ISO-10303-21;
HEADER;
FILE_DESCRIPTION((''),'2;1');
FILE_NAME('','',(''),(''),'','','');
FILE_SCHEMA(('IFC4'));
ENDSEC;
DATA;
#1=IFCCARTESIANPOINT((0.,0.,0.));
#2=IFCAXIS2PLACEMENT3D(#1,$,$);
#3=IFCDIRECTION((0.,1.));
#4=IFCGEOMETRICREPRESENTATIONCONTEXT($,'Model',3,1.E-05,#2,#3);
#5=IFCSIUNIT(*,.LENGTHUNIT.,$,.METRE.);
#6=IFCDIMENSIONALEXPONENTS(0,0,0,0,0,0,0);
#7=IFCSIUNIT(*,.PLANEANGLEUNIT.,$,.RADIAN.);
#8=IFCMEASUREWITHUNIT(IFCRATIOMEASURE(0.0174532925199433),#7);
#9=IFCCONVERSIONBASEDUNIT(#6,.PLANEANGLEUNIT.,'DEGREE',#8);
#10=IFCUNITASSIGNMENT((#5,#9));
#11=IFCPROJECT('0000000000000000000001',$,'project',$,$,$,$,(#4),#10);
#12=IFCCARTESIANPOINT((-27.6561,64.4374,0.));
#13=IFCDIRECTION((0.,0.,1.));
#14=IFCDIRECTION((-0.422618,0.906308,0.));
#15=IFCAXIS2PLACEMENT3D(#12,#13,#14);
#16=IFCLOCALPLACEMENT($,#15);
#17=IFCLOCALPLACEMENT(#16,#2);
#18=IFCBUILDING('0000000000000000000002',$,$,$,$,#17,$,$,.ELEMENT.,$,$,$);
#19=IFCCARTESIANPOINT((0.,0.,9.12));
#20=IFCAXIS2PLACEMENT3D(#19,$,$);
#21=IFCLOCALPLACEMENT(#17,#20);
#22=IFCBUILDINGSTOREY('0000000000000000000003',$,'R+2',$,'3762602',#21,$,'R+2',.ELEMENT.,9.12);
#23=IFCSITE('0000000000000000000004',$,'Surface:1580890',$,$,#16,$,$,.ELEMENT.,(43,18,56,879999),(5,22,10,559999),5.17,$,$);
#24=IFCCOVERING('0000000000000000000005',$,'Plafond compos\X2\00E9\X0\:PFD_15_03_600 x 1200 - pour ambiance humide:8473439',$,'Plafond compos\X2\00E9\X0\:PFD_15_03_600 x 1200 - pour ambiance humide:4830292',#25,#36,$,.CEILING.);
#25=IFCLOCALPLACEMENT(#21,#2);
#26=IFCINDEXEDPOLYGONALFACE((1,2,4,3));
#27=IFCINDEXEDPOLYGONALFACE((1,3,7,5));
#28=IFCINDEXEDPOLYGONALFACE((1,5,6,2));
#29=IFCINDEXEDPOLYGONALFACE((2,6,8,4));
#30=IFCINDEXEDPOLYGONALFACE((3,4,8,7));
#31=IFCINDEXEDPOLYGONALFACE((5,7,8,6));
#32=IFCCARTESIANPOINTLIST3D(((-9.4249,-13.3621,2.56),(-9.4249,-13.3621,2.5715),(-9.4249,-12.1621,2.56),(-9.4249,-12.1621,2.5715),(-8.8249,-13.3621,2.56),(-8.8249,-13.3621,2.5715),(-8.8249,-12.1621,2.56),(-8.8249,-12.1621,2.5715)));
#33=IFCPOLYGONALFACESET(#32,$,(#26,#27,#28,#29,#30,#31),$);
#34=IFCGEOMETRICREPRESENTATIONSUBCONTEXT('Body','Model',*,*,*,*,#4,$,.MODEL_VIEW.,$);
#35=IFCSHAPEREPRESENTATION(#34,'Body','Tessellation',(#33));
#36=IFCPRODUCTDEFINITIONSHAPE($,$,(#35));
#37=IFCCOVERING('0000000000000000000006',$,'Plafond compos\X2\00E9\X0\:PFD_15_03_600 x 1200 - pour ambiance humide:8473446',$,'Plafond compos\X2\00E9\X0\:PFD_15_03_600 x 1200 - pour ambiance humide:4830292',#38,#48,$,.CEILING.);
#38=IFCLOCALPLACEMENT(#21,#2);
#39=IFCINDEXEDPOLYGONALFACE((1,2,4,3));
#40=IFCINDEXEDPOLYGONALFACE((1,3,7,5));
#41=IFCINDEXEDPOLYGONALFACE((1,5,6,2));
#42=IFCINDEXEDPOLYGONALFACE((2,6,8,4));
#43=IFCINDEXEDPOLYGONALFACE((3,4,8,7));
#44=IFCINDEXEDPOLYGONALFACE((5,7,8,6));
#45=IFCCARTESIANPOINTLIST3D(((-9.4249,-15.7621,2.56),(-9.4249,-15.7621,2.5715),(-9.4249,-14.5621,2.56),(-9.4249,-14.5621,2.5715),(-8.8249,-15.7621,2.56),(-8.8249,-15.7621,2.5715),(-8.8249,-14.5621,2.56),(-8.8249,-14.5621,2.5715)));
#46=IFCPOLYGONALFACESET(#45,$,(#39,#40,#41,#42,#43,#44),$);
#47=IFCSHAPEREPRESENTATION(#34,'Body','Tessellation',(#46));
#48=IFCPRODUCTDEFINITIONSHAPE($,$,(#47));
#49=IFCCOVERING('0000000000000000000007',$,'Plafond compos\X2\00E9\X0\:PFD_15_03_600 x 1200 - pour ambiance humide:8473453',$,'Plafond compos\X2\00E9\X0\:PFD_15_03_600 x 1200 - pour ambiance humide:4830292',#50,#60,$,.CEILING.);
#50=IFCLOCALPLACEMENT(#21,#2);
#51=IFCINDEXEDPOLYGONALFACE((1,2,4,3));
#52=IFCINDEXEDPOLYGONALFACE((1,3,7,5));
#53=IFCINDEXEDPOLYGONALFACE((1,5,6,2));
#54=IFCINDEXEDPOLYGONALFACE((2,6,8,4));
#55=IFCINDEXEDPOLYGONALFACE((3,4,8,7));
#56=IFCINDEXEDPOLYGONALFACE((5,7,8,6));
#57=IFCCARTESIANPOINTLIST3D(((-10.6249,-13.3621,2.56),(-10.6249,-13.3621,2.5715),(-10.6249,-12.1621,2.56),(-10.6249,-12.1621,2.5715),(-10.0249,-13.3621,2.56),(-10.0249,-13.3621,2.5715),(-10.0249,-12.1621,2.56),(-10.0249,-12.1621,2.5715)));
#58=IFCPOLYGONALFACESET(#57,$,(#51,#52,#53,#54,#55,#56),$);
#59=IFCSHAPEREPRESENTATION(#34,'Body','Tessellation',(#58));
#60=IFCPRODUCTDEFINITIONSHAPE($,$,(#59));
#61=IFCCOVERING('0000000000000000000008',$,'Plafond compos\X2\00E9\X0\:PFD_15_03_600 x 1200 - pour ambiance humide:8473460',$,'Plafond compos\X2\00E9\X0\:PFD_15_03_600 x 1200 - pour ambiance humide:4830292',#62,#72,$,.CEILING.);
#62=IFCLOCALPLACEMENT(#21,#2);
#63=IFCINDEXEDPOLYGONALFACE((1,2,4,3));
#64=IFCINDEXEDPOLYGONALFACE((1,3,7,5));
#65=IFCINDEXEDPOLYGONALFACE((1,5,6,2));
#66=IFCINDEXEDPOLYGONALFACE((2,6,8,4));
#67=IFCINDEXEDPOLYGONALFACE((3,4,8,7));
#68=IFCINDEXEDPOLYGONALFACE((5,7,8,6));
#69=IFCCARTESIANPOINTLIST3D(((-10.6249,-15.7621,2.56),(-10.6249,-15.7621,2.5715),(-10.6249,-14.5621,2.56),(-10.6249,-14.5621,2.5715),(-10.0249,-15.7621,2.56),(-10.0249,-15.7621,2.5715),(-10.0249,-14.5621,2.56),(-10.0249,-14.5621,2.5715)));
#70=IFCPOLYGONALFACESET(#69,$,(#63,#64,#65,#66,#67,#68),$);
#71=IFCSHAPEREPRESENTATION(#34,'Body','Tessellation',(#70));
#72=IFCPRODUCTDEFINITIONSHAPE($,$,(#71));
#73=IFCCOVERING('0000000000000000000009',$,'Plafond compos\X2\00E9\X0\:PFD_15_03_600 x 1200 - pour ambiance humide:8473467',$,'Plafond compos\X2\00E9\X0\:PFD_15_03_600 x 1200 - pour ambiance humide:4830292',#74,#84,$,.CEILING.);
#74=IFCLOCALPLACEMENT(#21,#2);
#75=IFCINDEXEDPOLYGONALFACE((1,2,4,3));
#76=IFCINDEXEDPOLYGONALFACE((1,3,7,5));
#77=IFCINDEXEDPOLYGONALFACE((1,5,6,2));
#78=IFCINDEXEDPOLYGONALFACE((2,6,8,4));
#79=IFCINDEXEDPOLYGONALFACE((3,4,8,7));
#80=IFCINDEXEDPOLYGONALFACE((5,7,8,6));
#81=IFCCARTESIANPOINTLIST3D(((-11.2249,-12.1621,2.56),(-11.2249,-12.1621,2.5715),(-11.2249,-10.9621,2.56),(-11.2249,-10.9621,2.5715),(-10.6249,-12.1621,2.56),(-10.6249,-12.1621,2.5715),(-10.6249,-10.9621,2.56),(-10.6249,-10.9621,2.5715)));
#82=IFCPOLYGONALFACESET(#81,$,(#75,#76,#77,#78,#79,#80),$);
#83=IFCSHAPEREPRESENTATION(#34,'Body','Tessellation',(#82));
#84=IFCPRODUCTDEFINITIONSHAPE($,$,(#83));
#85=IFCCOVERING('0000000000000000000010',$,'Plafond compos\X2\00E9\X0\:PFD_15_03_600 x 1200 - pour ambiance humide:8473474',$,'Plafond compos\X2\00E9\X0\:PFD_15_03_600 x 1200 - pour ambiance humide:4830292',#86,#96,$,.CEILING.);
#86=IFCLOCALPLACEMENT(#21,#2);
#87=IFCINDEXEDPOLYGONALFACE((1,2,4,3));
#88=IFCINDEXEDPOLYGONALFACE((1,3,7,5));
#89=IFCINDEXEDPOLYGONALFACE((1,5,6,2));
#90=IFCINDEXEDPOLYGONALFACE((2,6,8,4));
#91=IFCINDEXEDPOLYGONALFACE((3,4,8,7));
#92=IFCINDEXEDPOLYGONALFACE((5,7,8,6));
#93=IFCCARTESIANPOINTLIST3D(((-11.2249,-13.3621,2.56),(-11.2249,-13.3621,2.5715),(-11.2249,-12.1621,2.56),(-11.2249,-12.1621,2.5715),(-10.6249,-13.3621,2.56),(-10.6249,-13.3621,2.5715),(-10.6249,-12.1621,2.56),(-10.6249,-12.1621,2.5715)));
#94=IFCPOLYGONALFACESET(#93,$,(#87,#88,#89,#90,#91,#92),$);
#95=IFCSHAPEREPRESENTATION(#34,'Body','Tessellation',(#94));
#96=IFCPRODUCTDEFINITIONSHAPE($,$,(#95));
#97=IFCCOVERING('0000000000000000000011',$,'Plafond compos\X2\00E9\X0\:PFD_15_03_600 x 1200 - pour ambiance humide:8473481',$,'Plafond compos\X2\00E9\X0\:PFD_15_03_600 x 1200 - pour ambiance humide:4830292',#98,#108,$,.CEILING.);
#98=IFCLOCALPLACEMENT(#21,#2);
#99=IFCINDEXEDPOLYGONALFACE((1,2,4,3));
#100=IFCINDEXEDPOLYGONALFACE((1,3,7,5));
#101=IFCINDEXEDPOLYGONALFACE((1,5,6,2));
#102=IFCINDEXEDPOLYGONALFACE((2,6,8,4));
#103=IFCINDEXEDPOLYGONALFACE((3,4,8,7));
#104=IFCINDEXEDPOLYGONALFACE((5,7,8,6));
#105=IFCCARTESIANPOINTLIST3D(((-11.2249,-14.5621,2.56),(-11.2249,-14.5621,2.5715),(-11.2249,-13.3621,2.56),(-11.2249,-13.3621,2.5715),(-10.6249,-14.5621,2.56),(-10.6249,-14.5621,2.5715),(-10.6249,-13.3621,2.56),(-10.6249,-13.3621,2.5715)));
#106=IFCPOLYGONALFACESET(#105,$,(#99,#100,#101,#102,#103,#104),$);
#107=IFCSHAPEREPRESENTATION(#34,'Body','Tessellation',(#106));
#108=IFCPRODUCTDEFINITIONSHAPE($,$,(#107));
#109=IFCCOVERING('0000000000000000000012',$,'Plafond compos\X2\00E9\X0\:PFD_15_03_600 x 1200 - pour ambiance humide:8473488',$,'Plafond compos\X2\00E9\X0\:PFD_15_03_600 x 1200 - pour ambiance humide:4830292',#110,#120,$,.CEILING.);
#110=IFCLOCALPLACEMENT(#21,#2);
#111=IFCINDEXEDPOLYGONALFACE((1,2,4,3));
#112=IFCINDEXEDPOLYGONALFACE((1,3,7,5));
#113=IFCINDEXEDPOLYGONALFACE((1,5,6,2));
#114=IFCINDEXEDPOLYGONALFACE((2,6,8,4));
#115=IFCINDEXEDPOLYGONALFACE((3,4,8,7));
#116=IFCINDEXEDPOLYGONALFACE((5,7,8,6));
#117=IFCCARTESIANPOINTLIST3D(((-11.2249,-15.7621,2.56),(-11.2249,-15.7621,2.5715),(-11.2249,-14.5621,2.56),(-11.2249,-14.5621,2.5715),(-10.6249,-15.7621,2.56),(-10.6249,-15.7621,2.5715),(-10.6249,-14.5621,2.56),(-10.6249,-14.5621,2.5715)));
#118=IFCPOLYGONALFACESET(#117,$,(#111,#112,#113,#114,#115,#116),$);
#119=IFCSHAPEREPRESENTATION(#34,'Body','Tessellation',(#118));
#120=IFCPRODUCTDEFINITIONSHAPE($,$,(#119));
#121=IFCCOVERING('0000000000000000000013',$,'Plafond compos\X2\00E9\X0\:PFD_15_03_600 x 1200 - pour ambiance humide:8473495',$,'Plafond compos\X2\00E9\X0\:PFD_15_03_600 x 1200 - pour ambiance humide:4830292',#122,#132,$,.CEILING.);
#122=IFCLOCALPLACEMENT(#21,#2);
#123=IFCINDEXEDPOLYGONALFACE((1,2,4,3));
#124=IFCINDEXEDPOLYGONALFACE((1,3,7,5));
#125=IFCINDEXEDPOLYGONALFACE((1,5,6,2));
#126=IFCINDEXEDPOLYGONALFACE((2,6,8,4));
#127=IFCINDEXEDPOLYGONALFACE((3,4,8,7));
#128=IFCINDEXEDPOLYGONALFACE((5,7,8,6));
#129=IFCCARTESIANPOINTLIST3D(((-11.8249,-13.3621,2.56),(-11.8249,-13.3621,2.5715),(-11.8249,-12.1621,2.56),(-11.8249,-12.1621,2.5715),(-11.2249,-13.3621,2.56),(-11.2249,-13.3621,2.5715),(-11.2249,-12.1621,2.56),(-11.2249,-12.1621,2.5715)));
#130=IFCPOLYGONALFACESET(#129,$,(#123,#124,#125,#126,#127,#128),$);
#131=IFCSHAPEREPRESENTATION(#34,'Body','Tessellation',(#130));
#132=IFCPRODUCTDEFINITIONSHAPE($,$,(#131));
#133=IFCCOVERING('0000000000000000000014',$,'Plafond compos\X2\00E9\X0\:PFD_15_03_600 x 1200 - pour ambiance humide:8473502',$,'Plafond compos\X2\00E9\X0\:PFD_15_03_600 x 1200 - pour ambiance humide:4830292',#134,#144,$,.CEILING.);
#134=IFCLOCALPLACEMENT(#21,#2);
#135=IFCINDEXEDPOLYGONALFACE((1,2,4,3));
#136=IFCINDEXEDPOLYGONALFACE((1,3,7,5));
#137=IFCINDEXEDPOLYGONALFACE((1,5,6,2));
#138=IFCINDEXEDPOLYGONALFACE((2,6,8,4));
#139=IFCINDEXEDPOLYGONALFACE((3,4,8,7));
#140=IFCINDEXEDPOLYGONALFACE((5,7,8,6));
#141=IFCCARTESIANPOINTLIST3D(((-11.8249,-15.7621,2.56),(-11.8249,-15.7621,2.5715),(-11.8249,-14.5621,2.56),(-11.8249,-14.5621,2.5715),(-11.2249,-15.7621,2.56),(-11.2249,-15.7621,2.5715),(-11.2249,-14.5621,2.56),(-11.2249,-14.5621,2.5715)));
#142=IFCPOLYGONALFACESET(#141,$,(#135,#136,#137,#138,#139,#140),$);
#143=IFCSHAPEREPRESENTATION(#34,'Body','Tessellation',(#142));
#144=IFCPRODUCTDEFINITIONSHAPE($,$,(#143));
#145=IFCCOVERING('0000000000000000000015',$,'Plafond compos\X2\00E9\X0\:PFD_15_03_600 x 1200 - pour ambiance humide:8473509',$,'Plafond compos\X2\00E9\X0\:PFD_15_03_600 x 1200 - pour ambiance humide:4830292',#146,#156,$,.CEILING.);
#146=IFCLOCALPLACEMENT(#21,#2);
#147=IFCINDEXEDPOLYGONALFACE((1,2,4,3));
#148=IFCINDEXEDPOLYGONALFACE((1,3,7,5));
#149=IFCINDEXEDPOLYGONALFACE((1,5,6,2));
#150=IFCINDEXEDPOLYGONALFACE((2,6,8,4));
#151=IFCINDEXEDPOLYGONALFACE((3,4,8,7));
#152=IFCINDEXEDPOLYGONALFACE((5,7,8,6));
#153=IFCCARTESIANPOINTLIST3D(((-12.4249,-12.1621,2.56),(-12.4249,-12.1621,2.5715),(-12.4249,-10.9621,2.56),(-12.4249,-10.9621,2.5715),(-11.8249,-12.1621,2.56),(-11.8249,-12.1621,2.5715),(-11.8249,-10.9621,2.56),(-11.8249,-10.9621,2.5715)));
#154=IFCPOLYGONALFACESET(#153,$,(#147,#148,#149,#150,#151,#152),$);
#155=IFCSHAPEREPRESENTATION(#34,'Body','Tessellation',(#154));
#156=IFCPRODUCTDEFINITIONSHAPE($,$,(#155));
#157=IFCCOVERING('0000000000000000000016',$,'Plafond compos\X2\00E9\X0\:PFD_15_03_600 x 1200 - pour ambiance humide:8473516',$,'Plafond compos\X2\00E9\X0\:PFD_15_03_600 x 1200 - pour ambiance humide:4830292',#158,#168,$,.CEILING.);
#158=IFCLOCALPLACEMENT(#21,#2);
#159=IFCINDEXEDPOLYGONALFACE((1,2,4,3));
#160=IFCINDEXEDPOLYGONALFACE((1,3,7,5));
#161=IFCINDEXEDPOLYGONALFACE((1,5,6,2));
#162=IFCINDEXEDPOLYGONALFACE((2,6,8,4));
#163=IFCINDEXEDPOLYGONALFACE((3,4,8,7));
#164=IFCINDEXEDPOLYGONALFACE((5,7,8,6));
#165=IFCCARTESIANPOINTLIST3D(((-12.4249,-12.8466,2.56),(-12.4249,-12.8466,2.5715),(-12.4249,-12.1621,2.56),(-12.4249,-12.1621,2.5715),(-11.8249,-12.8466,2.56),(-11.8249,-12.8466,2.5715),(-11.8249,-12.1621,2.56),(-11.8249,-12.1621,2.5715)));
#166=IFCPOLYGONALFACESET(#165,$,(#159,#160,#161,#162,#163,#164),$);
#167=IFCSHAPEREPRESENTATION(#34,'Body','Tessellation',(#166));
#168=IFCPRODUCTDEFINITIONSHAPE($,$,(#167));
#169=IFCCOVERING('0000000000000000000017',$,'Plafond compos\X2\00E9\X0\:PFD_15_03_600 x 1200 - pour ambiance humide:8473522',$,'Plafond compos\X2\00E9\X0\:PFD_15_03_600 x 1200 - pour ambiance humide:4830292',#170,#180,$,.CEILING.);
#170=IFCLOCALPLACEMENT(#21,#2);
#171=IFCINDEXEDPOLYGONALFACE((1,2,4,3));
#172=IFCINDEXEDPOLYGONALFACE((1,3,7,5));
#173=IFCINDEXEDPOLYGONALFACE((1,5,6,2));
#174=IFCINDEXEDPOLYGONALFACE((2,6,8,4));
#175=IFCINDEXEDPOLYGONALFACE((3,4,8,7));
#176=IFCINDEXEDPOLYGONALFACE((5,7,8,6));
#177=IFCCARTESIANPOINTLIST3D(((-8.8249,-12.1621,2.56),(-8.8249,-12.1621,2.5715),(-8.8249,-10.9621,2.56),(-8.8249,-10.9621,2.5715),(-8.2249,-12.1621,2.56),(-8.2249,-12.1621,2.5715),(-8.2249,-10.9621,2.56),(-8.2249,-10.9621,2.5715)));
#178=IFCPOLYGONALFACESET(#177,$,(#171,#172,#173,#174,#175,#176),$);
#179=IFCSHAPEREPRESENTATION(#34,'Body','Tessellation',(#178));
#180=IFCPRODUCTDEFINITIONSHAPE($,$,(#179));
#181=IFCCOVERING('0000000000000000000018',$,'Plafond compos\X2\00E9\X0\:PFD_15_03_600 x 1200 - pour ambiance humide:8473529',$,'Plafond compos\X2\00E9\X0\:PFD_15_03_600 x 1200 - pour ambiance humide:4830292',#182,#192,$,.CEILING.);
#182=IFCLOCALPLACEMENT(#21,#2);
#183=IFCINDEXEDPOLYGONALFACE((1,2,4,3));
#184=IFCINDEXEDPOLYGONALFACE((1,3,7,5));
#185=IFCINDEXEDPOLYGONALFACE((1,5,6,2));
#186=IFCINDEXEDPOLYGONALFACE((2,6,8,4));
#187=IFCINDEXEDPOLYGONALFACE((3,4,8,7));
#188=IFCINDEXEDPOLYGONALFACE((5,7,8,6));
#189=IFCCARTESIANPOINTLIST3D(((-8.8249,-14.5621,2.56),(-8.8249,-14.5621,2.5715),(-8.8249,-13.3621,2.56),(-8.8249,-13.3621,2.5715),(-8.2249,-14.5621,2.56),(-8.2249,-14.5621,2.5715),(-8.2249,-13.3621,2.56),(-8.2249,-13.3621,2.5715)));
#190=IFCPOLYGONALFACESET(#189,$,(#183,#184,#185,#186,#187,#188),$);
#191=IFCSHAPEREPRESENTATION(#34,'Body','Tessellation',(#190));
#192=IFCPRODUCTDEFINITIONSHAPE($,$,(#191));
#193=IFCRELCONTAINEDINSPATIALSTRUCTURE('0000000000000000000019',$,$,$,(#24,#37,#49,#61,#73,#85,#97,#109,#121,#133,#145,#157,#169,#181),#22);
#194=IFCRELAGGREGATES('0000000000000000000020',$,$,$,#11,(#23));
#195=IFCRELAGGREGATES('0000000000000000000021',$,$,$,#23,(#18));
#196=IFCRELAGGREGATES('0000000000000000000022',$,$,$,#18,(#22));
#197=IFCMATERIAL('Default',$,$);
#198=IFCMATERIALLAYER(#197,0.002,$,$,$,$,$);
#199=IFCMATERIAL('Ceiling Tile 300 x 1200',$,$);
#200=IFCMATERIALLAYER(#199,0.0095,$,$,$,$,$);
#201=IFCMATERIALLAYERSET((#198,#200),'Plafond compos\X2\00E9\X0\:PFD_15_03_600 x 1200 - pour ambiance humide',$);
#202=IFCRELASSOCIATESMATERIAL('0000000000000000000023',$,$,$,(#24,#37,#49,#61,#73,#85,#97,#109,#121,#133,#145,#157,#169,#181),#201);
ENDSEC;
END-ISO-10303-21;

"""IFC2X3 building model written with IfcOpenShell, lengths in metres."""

from ifc_helpers import new_model, entity, si_unit, converted_unit, direction, frame, frame_2d, origin, origin_2d_with_axis, place, context, subcontext, project, spatial, rectangle, extrude, material, layer, layer_set, layer_usage, element, save


model = new_model("IFC2X3")

# Units and contexts
model_context = context("Model", 3, precision=1e-05, world=origin(), true_north=direction((0.0, 1.0)))
body_context = subcontext(model_context, "Body", "Model", "MODEL_VIEW")
ifc_project = project(units=[si_unit("LENGTHUNIT", "METRE"), converted_unit("PLANEANGLEUNIT", "DEGREE", entity("IfcRatioMeasure", 0.0174532925199433), si_unit("PLANEANGLEUNIT", "RADIAN"), dimensions=[0, 0, 0, 0, 0, 0, 0])], contexts=[model_context])

# Site, building, storey
site_placement = place(None, frame((-27.6561, 64.4374, 0.0), z_axis=(0.0, 0.0, 1.0), x_axis=(-0.422618, 0.906308, 0.0)))
site = spatial("IfcSite", under=ifc_project, at=site_placement, Name="Surface:1580890", CompositionType="ELEMENT", RefLatitude=(43, 18, 56, 879999), RefLongitude=(5, 22, 10, 559999), RefElevation=5.17)
building_placement = place(site_placement, origin())
building = spatial("IfcBuilding", under=site, at=building_placement, CompositionType="ELEMENT")
storey_placement = place(building_placement, frame((0.0, 0.0, 9.12)))
storey = spatial("IfcBuildingStorey", under=building, at=storey_placement, Name="R+2", ObjectType="3762602", LongName="R+2", CompositionType="ELEMENT", Elevation=9.12)

# Coverings
ifc_material_1 = material(Name="Default")
ifc_layer_1 = layer(ifc_material_1, 0.002)
ifc_material_2 = material(Name="Ceiling Tile 300 x 1200")
ifc_layer_2 = layer(ifc_material_2, 0.0095)
ifc_layer_set = layer_set([ifc_layer_1, ifc_layer_2], Name="Plafond composé:PFD_15_03_600 x 1200 - pour ambiance humide")
ifc_layer_usage_1 = layer_usage(ifc_layer_set, "AXIS3", "POSITIVE", 0.0)
covering_1_placement = place(storey_placement, origin())
element("IfcCovering", 1, at=covering_1_placement, inside=storey, material=ifc_layer_usage_1, Name="Plafond composé:PFD_15_03_600 x 1200 - pour ambiance humide:8473439", ObjectType="Plafond composé:PFD_15_03_600 x 1200 - pour ambiance humide:4830292", PredefinedType="CEILING", context=body_context, shape_type="SweptSolid", body=[
    extrude(rectangle(XDim=0.6, YDim=1.2, at=frame_2d((0.0, 0.0), x_axis=(1.0, 0.0))), frame((-9.1249, -12.7621, 2.56), z_axis=(0.0, 0.0, 1.0), x_axis=(-1.0, 0.0, 0.0)), (0.0, 0.0, 1.0), 0.0115),
])
ifc_layer_usage_2 = layer_usage(ifc_layer_set, "AXIS3", "POSITIVE", 0.0)
covering_2_placement = place(storey_placement, origin())
element("IfcCovering", 2, at=covering_2_placement, inside=storey, material=ifc_layer_usage_2, Name="Plafond composé:PFD_15_03_600 x 1200 - pour ambiance humide:8473446", ObjectType="Plafond composé:PFD_15_03_600 x 1200 - pour ambiance humide:4830292", PredefinedType="CEILING", context=body_context, shape_type="SweptSolid", body=[
    extrude(rectangle(XDim=0.6, YDim=1.2, at=origin_2d_with_axis()), frame((-9.1249, -15.1621, 2.56), z_axis=(0.0, 0.0, 1.0), x_axis=(-1.0, 0.0, 0.0)), (0.0, 0.0, 1.0), 0.0115),
])
ifc_layer_usage_3 = layer_usage(ifc_layer_set, "AXIS3", "POSITIVE", 0.0)
covering_3_placement = place(storey_placement, origin())
element("IfcCovering", 3, at=covering_3_placement, inside=storey, material=ifc_layer_usage_3, Name="Plafond composé:PFD_15_03_600 x 1200 - pour ambiance humide:8473453", ObjectType="Plafond composé:PFD_15_03_600 x 1200 - pour ambiance humide:4830292", PredefinedType="CEILING", context=body_context, shape_type="SweptSolid", body=[
    extrude(rectangle(XDim=0.6, YDim=1.2, at=origin_2d_with_axis()), frame((-10.3249, -12.7621, 2.56), z_axis=(0.0, 0.0, 1.0), x_axis=(-1.0, 0.0, 0.0)), (0.0, 0.0, 1.0), 0.0115),
])
ifc_layer_usage_4 = layer_usage(ifc_layer_set, "AXIS3", "POSITIVE", 0.0)
covering_4_placement = place(storey_placement, origin())
element("IfcCovering", 4, at=covering_4_placement, inside=storey, material=ifc_layer_usage_4, Name="Plafond composé:PFD_15_03_600 x 1200 - pour ambiance humide:8473460", ObjectType="Plafond composé:PFD_15_03_600 x 1200 - pour ambiance humide:4830292", PredefinedType="CEILING", context=body_context, shape_type="SweptSolid", body=[
    extrude(rectangle(XDim=0.6, YDim=1.2, at=origin_2d_with_axis()), frame((-10.3249, -15.1621, 2.56), z_axis=(0.0, 0.0, 1.0), x_axis=(-1.0, 0.0, 0.0)), (0.0, 0.0, 1.0), 0.0115),
])
ifc_layer_usage_5 = layer_usage(ifc_layer_set, "AXIS3", "POSITIVE", 0.0)
covering_5_placement = place(storey_placement, origin())
element("IfcCovering", 5, at=covering_5_placement, inside=storey, material=ifc_layer_usage_5, Name="Plafond composé:PFD_15_03_600 x 1200 - pour ambiance humide:8473467", ObjectType="Plafond composé:PFD_15_03_600 x 1200 - pour ambiance humide:4830292", PredefinedType="CEILING", context=body_context, shape_type="SweptSolid", body=[
    extrude(rectangle(XDim=0.6, YDim=1.2, at=origin_2d_with_axis()), frame((-10.9249, -11.5621, 2.56), z_axis=(0.0, 0.0, 1.0), x_axis=(-1.0, 0.0, 0.0)), (0.0, 0.0, 1.0), 0.0115),
])
ifc_layer_usage_6 = layer_usage(ifc_layer_set, "AXIS3", "POSITIVE", 0.0)
covering_6_placement = place(storey_placement, origin())
element("IfcCovering", 6, at=covering_6_placement, inside=storey, material=ifc_layer_usage_6, Name="Plafond composé:PFD_15_03_600 x 1200 - pour ambiance humide:8473474", ObjectType="Plafond composé:PFD_15_03_600 x 1200 - pour ambiance humide:4830292", PredefinedType="CEILING", context=body_context, shape_type="SweptSolid", body=[
    extrude(rectangle(XDim=0.6, YDim=1.2, at=origin_2d_with_axis()), frame((-10.9249, -12.7621, 2.56), z_axis=(0.0, 0.0, 1.0), x_axis=(-1.0, 0.0, 0.0)), (0.0, 0.0, 1.0), 0.0115),
])
ifc_layer_usage_7 = layer_usage(ifc_layer_set, "AXIS3", "POSITIVE", 0.0)
covering_7_placement = place(storey_placement, origin())
element("IfcCovering", 7, at=covering_7_placement, inside=storey, material=ifc_layer_usage_7, Name="Plafond composé:PFD_15_03_600 x 1200 - pour ambiance humide:8473481", ObjectType="Plafond composé:PFD_15_03_600 x 1200 - pour ambiance humide:4830292", PredefinedType="CEILING", context=body_context, shape_type="SweptSolid", body=[
    extrude(rectangle(XDim=0.6, YDim=1.2, at=origin_2d_with_axis()), frame((-10.9249, -13.9621, 2.56), z_axis=(0.0, 0.0, 1.0), x_axis=(-1.0, 0.0, 0.0)), (0.0, 0.0, 1.0), 0.0115),
])
ifc_layer_usage_8 = layer_usage(ifc_layer_set, "AXIS3", "POSITIVE", 0.0)
covering_8_placement = place(storey_placement, origin())
element("IfcCovering", 8, at=covering_8_placement, inside=storey, material=ifc_layer_usage_8, Name="Plafond composé:PFD_15_03_600 x 1200 - pour ambiance humide:8473488", ObjectType="Plafond composé:PFD_15_03_600 x 1200 - pour ambiance humide:4830292", PredefinedType="CEILING", context=body_context, shape_type="SweptSolid", body=[
    extrude(rectangle(XDim=0.6, YDim=1.2, at=origin_2d_with_axis()), frame((-10.9249, -15.1621, 2.56), z_axis=(0.0, 0.0, 1.0), x_axis=(-1.0, 0.0, 0.0)), (0.0, 0.0, 1.0), 0.0115),
])
ifc_layer_usage_9 = layer_usage(ifc_layer_set, "AXIS3", "POSITIVE", 0.0)
covering_9_placement = place(storey_placement, origin())
element("IfcCovering", 9, at=covering_9_placement, inside=storey, material=ifc_layer_usage_9, Name="Plafond composé:PFD_15_03_600 x 1200 - pour ambiance humide:8473495", ObjectType="Plafond composé:PFD_15_03_600 x 1200 - pour ambiance humide:4830292", PredefinedType="CEILING", context=body_context, shape_type="SweptSolid", body=[
    extrude(rectangle(XDim=0.6, YDim=1.2, at=origin_2d_with_axis()), frame((-11.5249, -12.7621, 2.56), z_axis=(0.0, 0.0, 1.0), x_axis=(-1.0, 0.0, 0.0)), (0.0, 0.0, 1.0), 0.0115),
])
ifc_layer_usage_10 = layer_usage(ifc_layer_set, "AXIS3", "POSITIVE", 0.0)
covering_10_placement = place(storey_placement, origin())
element("IfcCovering", 10, at=covering_10_placement, inside=storey, material=ifc_layer_usage_10, Name="Plafond composé:PFD_15_03_600 x 1200 - pour ambiance humide:8473502", ObjectType="Plafond composé:PFD_15_03_600 x 1200 - pour ambiance humide:4830292", PredefinedType="CEILING", context=body_context, shape_type="SweptSolid", body=[
    extrude(rectangle(XDim=0.6, YDim=1.2, at=origin_2d_with_axis()), frame((-11.5249, -15.1621, 2.56), z_axis=(0.0, 0.0, 1.0), x_axis=(-1.0, 0.0, 0.0)), (0.0, 0.0, 1.0), 0.0115),
])
ifc_layer_usage_11 = layer_usage(ifc_layer_set, "AXIS3", "POSITIVE", 0.0)
covering_11_placement = place(storey_placement, origin())
element("IfcCovering", 11, at=covering_11_placement, inside=storey, material=ifc_layer_usage_11, Name="Plafond composé:PFD_15_03_600 x 1200 - pour ambiance humide:8473509", ObjectType="Plafond composé:PFD_15_03_600 x 1200 - pour ambiance humide:4830292", PredefinedType="CEILING", context=body_context, shape_type="SweptSolid", body=[
    extrude(rectangle(XDim=0.6, YDim=1.2, at=origin_2d_with_axis()), frame((-12.1249, -11.5621, 2.56), z_axis=(0.0, 0.0, 1.0), x_axis=(-1.0, 0.0, 0.0)), (0.0, 0.0, 1.0), 0.0115),
])
ifc_layer_usage_12 = layer_usage(ifc_layer_set, "AXIS3", "POSITIVE", 0.0)
covering_12_placement = place(storey_placement, origin())
element("IfcCovering", 12, at=covering_12_placement, inside=storey, material=ifc_layer_usage_12, Name="Plafond composé:PFD_15_03_600 x 1200 - pour ambiance humide:8473516", ObjectType="Plafond composé:PFD_15_03_600 x 1200 - pour ambiance humide:4830292", PredefinedType="CEILING", context=body_context, shape_type="SweptSolid", body=[
    extrude(rectangle(XDim=0.6, YDim=0.6845, at=frame_2d((0.0, 0.0), x_axis=(1.0, 0.0))), frame((-12.1249, -12.5043, 2.56), z_axis=(0.0, 0.0, 1.0), x_axis=(-1.0, 0.0, 0.0)), (0.0, 0.0, 1.0), 0.0115),
])
ifc_layer_usage_13 = layer_usage(ifc_layer_set, "AXIS3", "POSITIVE", 0.0)
covering_13_placement = place(storey_placement, origin())
element("IfcCovering", 13, at=covering_13_placement, inside=storey, material=ifc_layer_usage_13, Name="Plafond composé:PFD_15_03_600 x 1200 - pour ambiance humide:8473522", ObjectType="Plafond composé:PFD_15_03_600 x 1200 - pour ambiance humide:4830292", PredefinedType="CEILING", context=body_context, shape_type="SweptSolid", body=[
    extrude(rectangle(XDim=0.6, YDim=1.2, at=origin_2d_with_axis()), frame((-8.5249, -11.5621, 2.56), z_axis=(0.0, 0.0, 1.0), x_axis=(-1.0, 0.0, 0.0)), (0.0, 0.0, 1.0), 0.0115),
])
ifc_layer_usage_14 = layer_usage(ifc_layer_set, "AXIS3", "POSITIVE", 0.0)
covering_14_placement = place(storey_placement, origin())
element("IfcCovering", 14, at=covering_14_placement, inside=storey, material=ifc_layer_usage_14, Name="Plafond composé:PFD_15_03_600 x 1200 - pour ambiance humide:8473529", ObjectType="Plafond composé:PFD_15_03_600 x 1200 - pour ambiance humide:4830292", PredefinedType="CEILING", context=body_context, shape_type="SweptSolid", body=[
    extrude(rectangle(XDim=0.6, YDim=1.2, at=origin_2d_with_axis()), frame((-8.5249, -13.9621, 2.56), z_axis=(0.0, 0.0, 1.0), x_axis=(-1.0, 0.0, 0.0)), (0.0, 0.0, 1.0), 0.0115),
])

save(model, "model.ifc")
